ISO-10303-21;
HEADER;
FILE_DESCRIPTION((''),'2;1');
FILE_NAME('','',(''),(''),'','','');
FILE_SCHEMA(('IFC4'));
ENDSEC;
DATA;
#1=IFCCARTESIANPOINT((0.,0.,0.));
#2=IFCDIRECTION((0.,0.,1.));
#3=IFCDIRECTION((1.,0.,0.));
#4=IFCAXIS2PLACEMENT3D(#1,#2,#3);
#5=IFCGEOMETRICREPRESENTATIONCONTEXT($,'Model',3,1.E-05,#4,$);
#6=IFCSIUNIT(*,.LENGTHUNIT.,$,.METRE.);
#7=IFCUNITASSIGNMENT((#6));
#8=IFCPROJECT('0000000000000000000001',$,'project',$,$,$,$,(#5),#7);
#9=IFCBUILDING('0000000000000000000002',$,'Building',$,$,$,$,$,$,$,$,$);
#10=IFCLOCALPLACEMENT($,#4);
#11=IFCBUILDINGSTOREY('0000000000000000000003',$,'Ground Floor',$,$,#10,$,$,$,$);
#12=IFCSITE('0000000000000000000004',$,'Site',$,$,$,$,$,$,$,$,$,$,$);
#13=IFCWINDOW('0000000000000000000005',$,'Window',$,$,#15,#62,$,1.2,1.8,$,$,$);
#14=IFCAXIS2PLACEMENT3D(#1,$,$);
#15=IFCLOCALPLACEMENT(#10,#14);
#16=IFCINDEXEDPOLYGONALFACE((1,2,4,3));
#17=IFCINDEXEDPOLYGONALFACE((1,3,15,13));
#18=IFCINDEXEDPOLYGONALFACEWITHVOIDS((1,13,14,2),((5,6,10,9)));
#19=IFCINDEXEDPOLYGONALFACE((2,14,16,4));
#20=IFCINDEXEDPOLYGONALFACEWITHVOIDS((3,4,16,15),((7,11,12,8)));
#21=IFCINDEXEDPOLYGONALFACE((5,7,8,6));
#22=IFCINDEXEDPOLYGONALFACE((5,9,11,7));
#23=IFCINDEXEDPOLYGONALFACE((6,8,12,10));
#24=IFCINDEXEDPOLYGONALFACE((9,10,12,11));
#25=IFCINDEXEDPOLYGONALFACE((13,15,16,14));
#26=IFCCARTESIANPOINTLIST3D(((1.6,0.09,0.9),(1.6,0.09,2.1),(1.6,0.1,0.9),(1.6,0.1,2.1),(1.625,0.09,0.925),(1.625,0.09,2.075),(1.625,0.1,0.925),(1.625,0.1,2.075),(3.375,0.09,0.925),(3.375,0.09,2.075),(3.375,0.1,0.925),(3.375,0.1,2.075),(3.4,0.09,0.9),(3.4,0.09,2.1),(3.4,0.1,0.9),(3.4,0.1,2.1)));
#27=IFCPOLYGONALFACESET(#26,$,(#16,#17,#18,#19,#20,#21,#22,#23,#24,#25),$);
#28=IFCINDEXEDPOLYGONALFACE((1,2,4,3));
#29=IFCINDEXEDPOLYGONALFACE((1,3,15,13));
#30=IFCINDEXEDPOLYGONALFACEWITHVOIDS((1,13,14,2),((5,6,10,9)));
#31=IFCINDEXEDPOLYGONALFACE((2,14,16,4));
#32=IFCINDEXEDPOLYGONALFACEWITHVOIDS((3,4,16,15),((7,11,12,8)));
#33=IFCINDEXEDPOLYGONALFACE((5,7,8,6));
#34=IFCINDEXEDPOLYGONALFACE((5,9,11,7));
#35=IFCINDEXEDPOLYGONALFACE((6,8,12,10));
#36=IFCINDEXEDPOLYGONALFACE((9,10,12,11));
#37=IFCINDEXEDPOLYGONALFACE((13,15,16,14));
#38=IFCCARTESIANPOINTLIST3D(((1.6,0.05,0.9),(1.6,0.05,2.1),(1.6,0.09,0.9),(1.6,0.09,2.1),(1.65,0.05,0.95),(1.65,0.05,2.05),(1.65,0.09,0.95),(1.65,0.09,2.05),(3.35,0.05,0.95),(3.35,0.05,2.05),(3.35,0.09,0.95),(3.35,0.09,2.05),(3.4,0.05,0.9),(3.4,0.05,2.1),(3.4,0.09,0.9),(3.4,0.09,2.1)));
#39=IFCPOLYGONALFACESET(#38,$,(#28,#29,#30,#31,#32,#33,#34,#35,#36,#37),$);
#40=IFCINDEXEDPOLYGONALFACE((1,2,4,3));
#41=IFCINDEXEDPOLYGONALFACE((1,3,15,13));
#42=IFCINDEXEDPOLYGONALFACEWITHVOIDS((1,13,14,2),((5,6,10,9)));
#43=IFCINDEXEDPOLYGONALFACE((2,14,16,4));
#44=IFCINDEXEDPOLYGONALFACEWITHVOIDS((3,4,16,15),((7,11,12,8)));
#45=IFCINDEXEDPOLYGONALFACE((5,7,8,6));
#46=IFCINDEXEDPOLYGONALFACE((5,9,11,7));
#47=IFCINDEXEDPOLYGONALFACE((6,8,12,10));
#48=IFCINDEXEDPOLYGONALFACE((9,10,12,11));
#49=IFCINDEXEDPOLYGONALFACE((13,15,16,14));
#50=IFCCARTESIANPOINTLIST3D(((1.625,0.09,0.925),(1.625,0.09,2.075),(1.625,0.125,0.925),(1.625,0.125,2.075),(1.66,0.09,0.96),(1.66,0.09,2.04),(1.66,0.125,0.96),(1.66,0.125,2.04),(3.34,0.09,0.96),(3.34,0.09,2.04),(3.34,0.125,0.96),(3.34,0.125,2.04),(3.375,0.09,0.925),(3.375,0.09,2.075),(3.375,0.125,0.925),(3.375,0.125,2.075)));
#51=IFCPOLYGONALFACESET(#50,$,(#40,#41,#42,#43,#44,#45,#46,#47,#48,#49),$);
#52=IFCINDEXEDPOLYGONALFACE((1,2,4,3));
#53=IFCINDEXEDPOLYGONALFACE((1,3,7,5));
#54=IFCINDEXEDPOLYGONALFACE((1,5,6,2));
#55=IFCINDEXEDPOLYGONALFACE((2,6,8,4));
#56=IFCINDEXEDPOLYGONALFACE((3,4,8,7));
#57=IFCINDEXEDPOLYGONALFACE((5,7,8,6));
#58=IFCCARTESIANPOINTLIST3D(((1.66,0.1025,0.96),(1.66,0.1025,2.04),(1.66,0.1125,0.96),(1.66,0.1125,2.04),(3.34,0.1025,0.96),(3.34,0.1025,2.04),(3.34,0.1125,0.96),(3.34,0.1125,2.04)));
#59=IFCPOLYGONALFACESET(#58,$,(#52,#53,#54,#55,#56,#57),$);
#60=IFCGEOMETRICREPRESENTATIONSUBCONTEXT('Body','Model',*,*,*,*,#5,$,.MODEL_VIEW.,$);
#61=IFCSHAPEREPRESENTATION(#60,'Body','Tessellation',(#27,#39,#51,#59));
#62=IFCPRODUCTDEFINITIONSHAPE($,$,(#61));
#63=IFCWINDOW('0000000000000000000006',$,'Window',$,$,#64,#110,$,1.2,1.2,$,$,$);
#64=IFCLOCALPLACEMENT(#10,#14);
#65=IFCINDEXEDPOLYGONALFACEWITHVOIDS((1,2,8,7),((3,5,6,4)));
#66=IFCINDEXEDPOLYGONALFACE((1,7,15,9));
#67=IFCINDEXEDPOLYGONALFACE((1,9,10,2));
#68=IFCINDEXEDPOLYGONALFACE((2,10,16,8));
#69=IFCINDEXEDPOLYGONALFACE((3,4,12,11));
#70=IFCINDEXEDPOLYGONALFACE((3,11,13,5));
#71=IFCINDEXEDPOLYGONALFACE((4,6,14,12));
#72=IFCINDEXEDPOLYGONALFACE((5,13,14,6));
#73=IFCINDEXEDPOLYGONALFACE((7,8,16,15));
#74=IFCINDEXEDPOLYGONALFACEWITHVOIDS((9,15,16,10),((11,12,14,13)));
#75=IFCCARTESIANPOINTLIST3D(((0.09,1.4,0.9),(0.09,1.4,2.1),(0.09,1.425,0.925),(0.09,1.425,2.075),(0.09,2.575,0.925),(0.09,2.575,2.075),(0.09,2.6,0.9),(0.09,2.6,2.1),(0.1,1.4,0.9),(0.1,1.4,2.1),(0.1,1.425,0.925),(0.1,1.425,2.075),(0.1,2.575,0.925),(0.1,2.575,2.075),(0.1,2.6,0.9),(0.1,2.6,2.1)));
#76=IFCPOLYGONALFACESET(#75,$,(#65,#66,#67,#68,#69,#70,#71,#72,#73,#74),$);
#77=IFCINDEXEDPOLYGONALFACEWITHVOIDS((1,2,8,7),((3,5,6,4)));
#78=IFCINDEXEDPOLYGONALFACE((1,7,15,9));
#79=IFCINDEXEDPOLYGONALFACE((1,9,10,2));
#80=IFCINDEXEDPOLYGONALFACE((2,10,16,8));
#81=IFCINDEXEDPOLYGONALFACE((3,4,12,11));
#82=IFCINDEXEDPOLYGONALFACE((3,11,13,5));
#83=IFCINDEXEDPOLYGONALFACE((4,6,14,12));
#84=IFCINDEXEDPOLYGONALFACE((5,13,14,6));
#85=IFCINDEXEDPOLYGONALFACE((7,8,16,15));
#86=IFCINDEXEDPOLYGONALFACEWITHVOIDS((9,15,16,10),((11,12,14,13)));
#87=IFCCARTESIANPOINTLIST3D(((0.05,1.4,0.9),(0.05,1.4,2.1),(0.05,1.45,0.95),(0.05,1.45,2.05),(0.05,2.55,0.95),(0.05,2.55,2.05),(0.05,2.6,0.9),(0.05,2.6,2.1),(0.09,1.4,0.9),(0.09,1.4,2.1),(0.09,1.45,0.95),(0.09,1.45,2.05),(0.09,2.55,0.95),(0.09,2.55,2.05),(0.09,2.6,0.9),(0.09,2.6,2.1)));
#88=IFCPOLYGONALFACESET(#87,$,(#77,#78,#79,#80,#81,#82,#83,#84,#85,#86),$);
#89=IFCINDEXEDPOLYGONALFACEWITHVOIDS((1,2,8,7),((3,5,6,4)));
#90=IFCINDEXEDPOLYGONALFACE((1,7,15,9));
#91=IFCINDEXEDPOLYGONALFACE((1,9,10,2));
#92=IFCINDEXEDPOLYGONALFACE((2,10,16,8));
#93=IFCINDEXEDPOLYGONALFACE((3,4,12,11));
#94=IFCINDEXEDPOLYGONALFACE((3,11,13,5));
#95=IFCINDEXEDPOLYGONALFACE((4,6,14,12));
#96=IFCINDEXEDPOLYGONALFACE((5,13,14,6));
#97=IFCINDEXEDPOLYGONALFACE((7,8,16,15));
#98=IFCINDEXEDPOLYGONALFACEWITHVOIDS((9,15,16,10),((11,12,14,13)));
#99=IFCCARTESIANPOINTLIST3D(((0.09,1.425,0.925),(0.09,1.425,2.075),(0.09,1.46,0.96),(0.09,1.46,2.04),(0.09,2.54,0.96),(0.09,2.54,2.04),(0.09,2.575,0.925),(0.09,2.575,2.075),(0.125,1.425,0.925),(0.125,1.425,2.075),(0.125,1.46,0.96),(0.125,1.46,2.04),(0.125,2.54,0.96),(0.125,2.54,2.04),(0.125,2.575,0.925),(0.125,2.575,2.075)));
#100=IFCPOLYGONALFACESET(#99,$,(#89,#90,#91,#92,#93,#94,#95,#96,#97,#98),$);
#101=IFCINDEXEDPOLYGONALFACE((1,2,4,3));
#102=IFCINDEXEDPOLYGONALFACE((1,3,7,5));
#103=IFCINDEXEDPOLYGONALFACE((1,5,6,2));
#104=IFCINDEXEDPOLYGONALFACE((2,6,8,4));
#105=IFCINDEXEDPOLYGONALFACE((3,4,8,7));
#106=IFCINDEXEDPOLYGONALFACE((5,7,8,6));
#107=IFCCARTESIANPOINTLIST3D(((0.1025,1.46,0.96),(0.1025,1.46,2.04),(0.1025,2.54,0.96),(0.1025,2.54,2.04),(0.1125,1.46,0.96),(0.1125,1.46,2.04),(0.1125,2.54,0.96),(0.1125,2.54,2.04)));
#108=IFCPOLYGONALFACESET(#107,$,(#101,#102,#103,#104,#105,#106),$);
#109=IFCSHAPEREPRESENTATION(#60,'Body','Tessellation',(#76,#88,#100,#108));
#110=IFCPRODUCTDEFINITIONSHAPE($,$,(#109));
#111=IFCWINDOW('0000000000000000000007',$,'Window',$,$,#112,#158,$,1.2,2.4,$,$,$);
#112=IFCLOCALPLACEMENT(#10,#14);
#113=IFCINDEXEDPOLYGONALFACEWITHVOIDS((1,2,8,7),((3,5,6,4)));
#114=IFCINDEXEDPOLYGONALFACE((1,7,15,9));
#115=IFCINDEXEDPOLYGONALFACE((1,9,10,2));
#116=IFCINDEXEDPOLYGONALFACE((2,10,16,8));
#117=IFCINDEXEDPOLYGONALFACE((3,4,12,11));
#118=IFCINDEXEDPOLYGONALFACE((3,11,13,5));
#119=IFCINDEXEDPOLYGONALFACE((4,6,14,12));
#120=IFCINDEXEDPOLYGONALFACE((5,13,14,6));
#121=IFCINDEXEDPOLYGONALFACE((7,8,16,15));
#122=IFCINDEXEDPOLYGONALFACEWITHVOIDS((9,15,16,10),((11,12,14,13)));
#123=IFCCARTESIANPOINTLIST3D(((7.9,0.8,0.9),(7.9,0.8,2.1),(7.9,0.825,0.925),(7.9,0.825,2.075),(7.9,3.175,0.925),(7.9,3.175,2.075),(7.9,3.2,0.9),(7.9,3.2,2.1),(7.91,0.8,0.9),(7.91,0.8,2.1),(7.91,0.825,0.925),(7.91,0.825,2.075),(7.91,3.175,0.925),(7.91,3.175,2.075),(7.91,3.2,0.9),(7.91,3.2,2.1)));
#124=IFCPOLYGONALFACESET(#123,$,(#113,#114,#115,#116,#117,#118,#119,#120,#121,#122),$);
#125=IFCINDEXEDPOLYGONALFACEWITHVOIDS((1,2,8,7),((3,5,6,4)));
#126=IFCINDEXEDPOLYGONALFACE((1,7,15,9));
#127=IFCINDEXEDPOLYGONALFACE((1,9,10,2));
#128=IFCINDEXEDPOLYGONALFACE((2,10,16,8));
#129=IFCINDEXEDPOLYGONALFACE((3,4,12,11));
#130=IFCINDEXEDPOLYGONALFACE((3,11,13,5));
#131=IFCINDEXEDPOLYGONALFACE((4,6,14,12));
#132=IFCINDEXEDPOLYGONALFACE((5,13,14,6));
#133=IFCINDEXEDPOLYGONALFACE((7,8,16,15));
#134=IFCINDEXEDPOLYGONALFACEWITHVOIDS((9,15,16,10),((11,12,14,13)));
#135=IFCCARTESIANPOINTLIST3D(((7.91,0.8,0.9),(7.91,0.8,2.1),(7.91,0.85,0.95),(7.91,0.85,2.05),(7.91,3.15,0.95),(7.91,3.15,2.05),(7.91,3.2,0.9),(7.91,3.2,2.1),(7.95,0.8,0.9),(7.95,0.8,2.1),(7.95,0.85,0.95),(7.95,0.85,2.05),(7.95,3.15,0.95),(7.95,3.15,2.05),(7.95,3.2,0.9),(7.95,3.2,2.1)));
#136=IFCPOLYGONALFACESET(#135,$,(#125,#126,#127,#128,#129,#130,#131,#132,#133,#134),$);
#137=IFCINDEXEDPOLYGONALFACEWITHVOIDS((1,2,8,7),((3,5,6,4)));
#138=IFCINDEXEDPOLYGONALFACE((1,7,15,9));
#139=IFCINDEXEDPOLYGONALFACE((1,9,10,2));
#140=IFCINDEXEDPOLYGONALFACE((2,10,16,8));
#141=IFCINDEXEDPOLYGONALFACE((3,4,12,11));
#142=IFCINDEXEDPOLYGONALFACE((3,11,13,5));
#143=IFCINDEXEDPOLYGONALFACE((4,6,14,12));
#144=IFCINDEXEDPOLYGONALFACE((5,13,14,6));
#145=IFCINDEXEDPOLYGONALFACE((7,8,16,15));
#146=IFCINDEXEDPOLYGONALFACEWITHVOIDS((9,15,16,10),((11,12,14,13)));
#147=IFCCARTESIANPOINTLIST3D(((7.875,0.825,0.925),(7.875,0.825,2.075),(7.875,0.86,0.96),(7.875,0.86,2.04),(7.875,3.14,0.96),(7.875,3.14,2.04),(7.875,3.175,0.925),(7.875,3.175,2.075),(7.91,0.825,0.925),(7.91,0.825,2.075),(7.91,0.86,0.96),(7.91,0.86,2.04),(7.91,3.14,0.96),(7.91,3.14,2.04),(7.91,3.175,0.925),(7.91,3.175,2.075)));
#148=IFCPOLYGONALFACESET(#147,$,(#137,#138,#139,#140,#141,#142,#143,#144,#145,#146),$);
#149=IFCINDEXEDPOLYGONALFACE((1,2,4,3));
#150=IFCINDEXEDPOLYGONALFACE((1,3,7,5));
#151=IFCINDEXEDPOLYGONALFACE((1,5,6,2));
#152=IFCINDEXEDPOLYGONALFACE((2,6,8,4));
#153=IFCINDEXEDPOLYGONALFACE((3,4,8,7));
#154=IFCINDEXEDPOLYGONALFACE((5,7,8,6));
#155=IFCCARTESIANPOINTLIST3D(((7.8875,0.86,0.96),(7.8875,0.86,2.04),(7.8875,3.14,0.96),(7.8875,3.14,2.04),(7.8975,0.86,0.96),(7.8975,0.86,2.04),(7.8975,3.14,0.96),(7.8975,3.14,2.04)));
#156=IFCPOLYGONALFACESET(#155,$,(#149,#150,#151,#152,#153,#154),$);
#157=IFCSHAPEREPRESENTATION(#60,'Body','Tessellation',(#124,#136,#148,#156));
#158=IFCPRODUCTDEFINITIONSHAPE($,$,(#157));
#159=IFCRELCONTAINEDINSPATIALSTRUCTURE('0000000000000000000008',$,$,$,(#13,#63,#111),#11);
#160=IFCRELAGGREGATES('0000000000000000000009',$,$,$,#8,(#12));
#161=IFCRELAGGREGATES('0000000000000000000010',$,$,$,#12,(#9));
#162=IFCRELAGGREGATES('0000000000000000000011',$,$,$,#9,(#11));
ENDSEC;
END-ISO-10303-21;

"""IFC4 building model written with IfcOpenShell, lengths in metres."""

from ifc_helpers import new_model, si_unit, frame, origin_with_axes, place, context, subcontext, project, spatial, line, indexed_curve, outline, extrude, element, save


model = new_model("IFC4")

# Units and contexts
model_context = context("Model", 3, precision=1e-05, world=origin_with_axes())
body_context = subcontext(model_context, "Body", "Model", "MODEL_VIEW")
ifc_project = project(units=[si_unit("LENGTHUNIT", "METRE")], contexts=[model_context])

# Site, building, storey
site = spatial("IfcSite", under=ifc_project, Name="Site")
building = spatial("IfcBuilding", under=site, Name="Building")
storey_placement = place(None, origin_with_axes())
storey = spatial("IfcBuildingStorey", under=building, at=storey_placement, Name="Ground Floor")

# Windows
window_1_placement = place(storey_placement, frame((1.6, 0.0, 0.9), z_axis=(0.0, 0.0, 1.0), x_axis=(1.0, 0.0, 0.0)))
element("IfcWindow", 1, at=window_1_placement, inside=storey, Name="Window", OverallHeight=1.2, OverallWidth=1.8, context=body_context, shape_type="SweptSolid", body=[
    extrude(outline(indexed_curve([(0.0, 0.0), (1.8, 0.0), (1.8, 1.2), (0.0, 1.2)], segments=[line(1, 2, 3, 4, 1)]), holes=[indexed_curve([(0.025, 0.025), (1.775, 0.025), (1.775, 1.175), (0.025, 1.175)], segments=[line(1, 2, 3, 4, 1)])]), frame((0.0, 0.09, 0.0), z_axis=(0.0, -1.0, 0.0), x_axis=(1.0, 0.0, 0.0)), (0.0, 0.0, -1.0), 0.01),
    extrude(outline(indexed_curve([(0.0, 0.0), (1.8, 0.0), (1.8, 1.2), (0.0, 1.2)], segments=[line(1, 2, 3, 4, 1)]), holes=[indexed_curve([(0.05, 0.05), (1.75, 0.05), (1.75, 1.15), (0.05, 1.15)], segments=[line(1, 2, 3, 4, 1)])]), frame((0.0, 0.05, 0.0), z_axis=(0.0, -1.0, 0.0), x_axis=(1.0, 0.0, 0.0)), (0.0, 0.0, -1.0), 0.04),
    extrude(outline(indexed_curve([(0.0, 0.0), (1.75, 0.0), (1.75, 1.15), (0.0, 1.15)], segments=[line(1, 2, 3, 4, 1)]), holes=[indexed_curve([(0.035, 0.035), (1.715, 0.035), (1.715, 1.115), (0.035, 1.115)], segments=[line(1, 2, 3, 4, 1)])]), frame((0.025, 0.09, 0.025), z_axis=(0.0, -1.0, 0.0), x_axis=(1.0, 0.0, 0.0)), (0.0, 0.0, -1.0), 0.035),
    extrude(outline(indexed_curve([(0.035, 0.035), (1.715, 0.035), (1.715, 1.115), (0.035, 1.115)], segments=[line(1, 2, 3, 4, 1)])), frame((0.025, 0.1025, 0.025), z_axis=(0.0, -1.0, 0.0), x_axis=(1.0, 0.0, 0.0)), (0.0, 0.0, -1.0), 0.01),
])
window_2_placement = place(storey_placement, frame((0.0, 2.6, 0.9), z_axis=(0.0, 0.0, 1.0), x_axis=(0.0, -1.0, 0.0)))
element("IfcWindow", 2, at=window_2_placement, inside=storey, Name="Window", OverallHeight=1.2, OverallWidth=1.2, context=body_context, shape_type="SweptSolid", body=[
    extrude(outline(indexed_curve([(0.0, 0.0), (1.2, 0.0), (1.2, 1.2), (0.0, 1.2)], segments=[line(1, 2, 3, 4, 1)]), holes=[indexed_curve([(0.025, 0.025), (1.175, 0.025), (1.175, 1.175), (0.025, 1.175)], segments=[line(1, 2, 3, 4, 1)])]), frame((0.0, 0.09, 0.0), z_axis=(0.0, -1.0, 0.0), x_axis=(1.0, 0.0, 0.0)), (0.0, 0.0, -1.0), 0.01),
    extrude(outline(indexed_curve([(0.0, 0.0), (1.2, 0.0), (1.2, 1.2), (0.0, 1.2)], segments=[line(1, 2, 3, 4, 1)]), holes=[indexed_curve([(0.05, 0.05), (1.15, 0.05), (1.15, 1.15), (0.05, 1.15)], segments=[line(1, 2, 3, 4, 1)])]), frame((0.0, 0.05, 0.0), z_axis=(0.0, -1.0, 0.0), x_axis=(1.0, 0.0, 0.0)), (0.0, 0.0, -1.0), 0.04),
    extrude(outline(indexed_curve([(0.0, 0.0), (1.15, 0.0), (1.15, 1.15), (0.0, 1.15)], segments=[line(1, 2, 3, 4, 1)]), holes=[indexed_curve([(0.035, 0.035), (1.115, 0.035), (1.115, 1.115), (0.035, 1.115)], segments=[line(1, 2, 3, 4, 1)])]), frame((0.025, 0.09, 0.025), z_axis=(0.0, -1.0, 0.0), x_axis=(1.0, 0.0, 0.0)), (0.0, 0.0, -1.0), 0.035),
    extrude(outline(indexed_curve([(0.035, 0.035), (1.115, 0.035), (1.115, 1.115), (0.035, 1.115)], segments=[line(1, 2, 3, 4, 1)])), frame((0.025, 0.1025, 0.025), z_axis=(0.0, -1.0, 0.0), x_axis=(1.0, 0.0, 0.0)), (0.0, 0.0, -1.0), 0.01),
])
window_3_placement = place(storey_placement, frame((8.0, 0.8, 0.9), z_axis=(0.0, 0.0, 1.0), x_axis=(0.0, 1.0, 0.0)))
element("IfcWindow", 3, at=window_3_placement, inside=storey, Name="Window", OverallHeight=1.2, OverallWidth=2.4, context=body_context, shape_type="SweptSolid", body=[
    extrude(outline(indexed_curve([(0.0, 0.0), (2.4, 0.0), (2.4, 1.2), (0.0, 1.2)], segments=[line(1, 2, 3, 4, 1)]), holes=[indexed_curve([(0.025, 0.025), (2.375, 0.025), (2.375, 1.175), (0.025, 1.175)], segments=[line(1, 2, 3, 4, 1)])]), frame((0.0, 0.09, 0.0), z_axis=(0.0, -1.0, 0.0), x_axis=(1.0, 0.0, 0.0)), (0.0, 0.0, -1.0), 0.01),
    extrude(outline(indexed_curve([(0.0, 0.0), (2.4, 0.0), (2.4, 1.2), (0.0, 1.2)], segments=[line(1, 2, 3, 4, 1)]), holes=[indexed_curve([(0.05, 0.05), (2.35, 0.05), (2.35, 1.15), (0.05, 1.15)], segments=[line(1, 2, 3, 4, 1)])]), frame((0.0, 0.05, 0.0), z_axis=(0.0, -1.0, 0.0), x_axis=(1.0, 0.0, 0.0)), (0.0, 0.0, -1.0), 0.04),
    extrude(outline(indexed_curve([(0.0, 0.0), (2.35, 0.0), (2.35, 1.15), (0.0, 1.15)], segments=[line(1, 2, 3, 4, 1)]), holes=[indexed_curve([(0.035, 0.035), (2.315, 0.035), (2.315, 1.115), (0.035, 1.115)], segments=[line(1, 2, 3, 4, 1)])]), frame((0.025, 0.09, 0.025), z_axis=(0.0, -1.0, 0.0), x_axis=(1.0, 0.0, 0.0)), (0.0, 0.0, -1.0), 0.035),
    extrude(outline(indexed_curve([(0.035, 0.035), (2.315, 0.035), (2.315, 1.115), (0.035, 1.115)], segments=[line(1, 2, 3, 4, 1)])), frame((0.025, 0.1025, 0.025), z_axis=(0.0, -1.0, 0.0), x_axis=(1.0, 0.0, 0.0)), (0.0, 0.0, -1.0), 0.01),
])

save(model, "model.ifc")
